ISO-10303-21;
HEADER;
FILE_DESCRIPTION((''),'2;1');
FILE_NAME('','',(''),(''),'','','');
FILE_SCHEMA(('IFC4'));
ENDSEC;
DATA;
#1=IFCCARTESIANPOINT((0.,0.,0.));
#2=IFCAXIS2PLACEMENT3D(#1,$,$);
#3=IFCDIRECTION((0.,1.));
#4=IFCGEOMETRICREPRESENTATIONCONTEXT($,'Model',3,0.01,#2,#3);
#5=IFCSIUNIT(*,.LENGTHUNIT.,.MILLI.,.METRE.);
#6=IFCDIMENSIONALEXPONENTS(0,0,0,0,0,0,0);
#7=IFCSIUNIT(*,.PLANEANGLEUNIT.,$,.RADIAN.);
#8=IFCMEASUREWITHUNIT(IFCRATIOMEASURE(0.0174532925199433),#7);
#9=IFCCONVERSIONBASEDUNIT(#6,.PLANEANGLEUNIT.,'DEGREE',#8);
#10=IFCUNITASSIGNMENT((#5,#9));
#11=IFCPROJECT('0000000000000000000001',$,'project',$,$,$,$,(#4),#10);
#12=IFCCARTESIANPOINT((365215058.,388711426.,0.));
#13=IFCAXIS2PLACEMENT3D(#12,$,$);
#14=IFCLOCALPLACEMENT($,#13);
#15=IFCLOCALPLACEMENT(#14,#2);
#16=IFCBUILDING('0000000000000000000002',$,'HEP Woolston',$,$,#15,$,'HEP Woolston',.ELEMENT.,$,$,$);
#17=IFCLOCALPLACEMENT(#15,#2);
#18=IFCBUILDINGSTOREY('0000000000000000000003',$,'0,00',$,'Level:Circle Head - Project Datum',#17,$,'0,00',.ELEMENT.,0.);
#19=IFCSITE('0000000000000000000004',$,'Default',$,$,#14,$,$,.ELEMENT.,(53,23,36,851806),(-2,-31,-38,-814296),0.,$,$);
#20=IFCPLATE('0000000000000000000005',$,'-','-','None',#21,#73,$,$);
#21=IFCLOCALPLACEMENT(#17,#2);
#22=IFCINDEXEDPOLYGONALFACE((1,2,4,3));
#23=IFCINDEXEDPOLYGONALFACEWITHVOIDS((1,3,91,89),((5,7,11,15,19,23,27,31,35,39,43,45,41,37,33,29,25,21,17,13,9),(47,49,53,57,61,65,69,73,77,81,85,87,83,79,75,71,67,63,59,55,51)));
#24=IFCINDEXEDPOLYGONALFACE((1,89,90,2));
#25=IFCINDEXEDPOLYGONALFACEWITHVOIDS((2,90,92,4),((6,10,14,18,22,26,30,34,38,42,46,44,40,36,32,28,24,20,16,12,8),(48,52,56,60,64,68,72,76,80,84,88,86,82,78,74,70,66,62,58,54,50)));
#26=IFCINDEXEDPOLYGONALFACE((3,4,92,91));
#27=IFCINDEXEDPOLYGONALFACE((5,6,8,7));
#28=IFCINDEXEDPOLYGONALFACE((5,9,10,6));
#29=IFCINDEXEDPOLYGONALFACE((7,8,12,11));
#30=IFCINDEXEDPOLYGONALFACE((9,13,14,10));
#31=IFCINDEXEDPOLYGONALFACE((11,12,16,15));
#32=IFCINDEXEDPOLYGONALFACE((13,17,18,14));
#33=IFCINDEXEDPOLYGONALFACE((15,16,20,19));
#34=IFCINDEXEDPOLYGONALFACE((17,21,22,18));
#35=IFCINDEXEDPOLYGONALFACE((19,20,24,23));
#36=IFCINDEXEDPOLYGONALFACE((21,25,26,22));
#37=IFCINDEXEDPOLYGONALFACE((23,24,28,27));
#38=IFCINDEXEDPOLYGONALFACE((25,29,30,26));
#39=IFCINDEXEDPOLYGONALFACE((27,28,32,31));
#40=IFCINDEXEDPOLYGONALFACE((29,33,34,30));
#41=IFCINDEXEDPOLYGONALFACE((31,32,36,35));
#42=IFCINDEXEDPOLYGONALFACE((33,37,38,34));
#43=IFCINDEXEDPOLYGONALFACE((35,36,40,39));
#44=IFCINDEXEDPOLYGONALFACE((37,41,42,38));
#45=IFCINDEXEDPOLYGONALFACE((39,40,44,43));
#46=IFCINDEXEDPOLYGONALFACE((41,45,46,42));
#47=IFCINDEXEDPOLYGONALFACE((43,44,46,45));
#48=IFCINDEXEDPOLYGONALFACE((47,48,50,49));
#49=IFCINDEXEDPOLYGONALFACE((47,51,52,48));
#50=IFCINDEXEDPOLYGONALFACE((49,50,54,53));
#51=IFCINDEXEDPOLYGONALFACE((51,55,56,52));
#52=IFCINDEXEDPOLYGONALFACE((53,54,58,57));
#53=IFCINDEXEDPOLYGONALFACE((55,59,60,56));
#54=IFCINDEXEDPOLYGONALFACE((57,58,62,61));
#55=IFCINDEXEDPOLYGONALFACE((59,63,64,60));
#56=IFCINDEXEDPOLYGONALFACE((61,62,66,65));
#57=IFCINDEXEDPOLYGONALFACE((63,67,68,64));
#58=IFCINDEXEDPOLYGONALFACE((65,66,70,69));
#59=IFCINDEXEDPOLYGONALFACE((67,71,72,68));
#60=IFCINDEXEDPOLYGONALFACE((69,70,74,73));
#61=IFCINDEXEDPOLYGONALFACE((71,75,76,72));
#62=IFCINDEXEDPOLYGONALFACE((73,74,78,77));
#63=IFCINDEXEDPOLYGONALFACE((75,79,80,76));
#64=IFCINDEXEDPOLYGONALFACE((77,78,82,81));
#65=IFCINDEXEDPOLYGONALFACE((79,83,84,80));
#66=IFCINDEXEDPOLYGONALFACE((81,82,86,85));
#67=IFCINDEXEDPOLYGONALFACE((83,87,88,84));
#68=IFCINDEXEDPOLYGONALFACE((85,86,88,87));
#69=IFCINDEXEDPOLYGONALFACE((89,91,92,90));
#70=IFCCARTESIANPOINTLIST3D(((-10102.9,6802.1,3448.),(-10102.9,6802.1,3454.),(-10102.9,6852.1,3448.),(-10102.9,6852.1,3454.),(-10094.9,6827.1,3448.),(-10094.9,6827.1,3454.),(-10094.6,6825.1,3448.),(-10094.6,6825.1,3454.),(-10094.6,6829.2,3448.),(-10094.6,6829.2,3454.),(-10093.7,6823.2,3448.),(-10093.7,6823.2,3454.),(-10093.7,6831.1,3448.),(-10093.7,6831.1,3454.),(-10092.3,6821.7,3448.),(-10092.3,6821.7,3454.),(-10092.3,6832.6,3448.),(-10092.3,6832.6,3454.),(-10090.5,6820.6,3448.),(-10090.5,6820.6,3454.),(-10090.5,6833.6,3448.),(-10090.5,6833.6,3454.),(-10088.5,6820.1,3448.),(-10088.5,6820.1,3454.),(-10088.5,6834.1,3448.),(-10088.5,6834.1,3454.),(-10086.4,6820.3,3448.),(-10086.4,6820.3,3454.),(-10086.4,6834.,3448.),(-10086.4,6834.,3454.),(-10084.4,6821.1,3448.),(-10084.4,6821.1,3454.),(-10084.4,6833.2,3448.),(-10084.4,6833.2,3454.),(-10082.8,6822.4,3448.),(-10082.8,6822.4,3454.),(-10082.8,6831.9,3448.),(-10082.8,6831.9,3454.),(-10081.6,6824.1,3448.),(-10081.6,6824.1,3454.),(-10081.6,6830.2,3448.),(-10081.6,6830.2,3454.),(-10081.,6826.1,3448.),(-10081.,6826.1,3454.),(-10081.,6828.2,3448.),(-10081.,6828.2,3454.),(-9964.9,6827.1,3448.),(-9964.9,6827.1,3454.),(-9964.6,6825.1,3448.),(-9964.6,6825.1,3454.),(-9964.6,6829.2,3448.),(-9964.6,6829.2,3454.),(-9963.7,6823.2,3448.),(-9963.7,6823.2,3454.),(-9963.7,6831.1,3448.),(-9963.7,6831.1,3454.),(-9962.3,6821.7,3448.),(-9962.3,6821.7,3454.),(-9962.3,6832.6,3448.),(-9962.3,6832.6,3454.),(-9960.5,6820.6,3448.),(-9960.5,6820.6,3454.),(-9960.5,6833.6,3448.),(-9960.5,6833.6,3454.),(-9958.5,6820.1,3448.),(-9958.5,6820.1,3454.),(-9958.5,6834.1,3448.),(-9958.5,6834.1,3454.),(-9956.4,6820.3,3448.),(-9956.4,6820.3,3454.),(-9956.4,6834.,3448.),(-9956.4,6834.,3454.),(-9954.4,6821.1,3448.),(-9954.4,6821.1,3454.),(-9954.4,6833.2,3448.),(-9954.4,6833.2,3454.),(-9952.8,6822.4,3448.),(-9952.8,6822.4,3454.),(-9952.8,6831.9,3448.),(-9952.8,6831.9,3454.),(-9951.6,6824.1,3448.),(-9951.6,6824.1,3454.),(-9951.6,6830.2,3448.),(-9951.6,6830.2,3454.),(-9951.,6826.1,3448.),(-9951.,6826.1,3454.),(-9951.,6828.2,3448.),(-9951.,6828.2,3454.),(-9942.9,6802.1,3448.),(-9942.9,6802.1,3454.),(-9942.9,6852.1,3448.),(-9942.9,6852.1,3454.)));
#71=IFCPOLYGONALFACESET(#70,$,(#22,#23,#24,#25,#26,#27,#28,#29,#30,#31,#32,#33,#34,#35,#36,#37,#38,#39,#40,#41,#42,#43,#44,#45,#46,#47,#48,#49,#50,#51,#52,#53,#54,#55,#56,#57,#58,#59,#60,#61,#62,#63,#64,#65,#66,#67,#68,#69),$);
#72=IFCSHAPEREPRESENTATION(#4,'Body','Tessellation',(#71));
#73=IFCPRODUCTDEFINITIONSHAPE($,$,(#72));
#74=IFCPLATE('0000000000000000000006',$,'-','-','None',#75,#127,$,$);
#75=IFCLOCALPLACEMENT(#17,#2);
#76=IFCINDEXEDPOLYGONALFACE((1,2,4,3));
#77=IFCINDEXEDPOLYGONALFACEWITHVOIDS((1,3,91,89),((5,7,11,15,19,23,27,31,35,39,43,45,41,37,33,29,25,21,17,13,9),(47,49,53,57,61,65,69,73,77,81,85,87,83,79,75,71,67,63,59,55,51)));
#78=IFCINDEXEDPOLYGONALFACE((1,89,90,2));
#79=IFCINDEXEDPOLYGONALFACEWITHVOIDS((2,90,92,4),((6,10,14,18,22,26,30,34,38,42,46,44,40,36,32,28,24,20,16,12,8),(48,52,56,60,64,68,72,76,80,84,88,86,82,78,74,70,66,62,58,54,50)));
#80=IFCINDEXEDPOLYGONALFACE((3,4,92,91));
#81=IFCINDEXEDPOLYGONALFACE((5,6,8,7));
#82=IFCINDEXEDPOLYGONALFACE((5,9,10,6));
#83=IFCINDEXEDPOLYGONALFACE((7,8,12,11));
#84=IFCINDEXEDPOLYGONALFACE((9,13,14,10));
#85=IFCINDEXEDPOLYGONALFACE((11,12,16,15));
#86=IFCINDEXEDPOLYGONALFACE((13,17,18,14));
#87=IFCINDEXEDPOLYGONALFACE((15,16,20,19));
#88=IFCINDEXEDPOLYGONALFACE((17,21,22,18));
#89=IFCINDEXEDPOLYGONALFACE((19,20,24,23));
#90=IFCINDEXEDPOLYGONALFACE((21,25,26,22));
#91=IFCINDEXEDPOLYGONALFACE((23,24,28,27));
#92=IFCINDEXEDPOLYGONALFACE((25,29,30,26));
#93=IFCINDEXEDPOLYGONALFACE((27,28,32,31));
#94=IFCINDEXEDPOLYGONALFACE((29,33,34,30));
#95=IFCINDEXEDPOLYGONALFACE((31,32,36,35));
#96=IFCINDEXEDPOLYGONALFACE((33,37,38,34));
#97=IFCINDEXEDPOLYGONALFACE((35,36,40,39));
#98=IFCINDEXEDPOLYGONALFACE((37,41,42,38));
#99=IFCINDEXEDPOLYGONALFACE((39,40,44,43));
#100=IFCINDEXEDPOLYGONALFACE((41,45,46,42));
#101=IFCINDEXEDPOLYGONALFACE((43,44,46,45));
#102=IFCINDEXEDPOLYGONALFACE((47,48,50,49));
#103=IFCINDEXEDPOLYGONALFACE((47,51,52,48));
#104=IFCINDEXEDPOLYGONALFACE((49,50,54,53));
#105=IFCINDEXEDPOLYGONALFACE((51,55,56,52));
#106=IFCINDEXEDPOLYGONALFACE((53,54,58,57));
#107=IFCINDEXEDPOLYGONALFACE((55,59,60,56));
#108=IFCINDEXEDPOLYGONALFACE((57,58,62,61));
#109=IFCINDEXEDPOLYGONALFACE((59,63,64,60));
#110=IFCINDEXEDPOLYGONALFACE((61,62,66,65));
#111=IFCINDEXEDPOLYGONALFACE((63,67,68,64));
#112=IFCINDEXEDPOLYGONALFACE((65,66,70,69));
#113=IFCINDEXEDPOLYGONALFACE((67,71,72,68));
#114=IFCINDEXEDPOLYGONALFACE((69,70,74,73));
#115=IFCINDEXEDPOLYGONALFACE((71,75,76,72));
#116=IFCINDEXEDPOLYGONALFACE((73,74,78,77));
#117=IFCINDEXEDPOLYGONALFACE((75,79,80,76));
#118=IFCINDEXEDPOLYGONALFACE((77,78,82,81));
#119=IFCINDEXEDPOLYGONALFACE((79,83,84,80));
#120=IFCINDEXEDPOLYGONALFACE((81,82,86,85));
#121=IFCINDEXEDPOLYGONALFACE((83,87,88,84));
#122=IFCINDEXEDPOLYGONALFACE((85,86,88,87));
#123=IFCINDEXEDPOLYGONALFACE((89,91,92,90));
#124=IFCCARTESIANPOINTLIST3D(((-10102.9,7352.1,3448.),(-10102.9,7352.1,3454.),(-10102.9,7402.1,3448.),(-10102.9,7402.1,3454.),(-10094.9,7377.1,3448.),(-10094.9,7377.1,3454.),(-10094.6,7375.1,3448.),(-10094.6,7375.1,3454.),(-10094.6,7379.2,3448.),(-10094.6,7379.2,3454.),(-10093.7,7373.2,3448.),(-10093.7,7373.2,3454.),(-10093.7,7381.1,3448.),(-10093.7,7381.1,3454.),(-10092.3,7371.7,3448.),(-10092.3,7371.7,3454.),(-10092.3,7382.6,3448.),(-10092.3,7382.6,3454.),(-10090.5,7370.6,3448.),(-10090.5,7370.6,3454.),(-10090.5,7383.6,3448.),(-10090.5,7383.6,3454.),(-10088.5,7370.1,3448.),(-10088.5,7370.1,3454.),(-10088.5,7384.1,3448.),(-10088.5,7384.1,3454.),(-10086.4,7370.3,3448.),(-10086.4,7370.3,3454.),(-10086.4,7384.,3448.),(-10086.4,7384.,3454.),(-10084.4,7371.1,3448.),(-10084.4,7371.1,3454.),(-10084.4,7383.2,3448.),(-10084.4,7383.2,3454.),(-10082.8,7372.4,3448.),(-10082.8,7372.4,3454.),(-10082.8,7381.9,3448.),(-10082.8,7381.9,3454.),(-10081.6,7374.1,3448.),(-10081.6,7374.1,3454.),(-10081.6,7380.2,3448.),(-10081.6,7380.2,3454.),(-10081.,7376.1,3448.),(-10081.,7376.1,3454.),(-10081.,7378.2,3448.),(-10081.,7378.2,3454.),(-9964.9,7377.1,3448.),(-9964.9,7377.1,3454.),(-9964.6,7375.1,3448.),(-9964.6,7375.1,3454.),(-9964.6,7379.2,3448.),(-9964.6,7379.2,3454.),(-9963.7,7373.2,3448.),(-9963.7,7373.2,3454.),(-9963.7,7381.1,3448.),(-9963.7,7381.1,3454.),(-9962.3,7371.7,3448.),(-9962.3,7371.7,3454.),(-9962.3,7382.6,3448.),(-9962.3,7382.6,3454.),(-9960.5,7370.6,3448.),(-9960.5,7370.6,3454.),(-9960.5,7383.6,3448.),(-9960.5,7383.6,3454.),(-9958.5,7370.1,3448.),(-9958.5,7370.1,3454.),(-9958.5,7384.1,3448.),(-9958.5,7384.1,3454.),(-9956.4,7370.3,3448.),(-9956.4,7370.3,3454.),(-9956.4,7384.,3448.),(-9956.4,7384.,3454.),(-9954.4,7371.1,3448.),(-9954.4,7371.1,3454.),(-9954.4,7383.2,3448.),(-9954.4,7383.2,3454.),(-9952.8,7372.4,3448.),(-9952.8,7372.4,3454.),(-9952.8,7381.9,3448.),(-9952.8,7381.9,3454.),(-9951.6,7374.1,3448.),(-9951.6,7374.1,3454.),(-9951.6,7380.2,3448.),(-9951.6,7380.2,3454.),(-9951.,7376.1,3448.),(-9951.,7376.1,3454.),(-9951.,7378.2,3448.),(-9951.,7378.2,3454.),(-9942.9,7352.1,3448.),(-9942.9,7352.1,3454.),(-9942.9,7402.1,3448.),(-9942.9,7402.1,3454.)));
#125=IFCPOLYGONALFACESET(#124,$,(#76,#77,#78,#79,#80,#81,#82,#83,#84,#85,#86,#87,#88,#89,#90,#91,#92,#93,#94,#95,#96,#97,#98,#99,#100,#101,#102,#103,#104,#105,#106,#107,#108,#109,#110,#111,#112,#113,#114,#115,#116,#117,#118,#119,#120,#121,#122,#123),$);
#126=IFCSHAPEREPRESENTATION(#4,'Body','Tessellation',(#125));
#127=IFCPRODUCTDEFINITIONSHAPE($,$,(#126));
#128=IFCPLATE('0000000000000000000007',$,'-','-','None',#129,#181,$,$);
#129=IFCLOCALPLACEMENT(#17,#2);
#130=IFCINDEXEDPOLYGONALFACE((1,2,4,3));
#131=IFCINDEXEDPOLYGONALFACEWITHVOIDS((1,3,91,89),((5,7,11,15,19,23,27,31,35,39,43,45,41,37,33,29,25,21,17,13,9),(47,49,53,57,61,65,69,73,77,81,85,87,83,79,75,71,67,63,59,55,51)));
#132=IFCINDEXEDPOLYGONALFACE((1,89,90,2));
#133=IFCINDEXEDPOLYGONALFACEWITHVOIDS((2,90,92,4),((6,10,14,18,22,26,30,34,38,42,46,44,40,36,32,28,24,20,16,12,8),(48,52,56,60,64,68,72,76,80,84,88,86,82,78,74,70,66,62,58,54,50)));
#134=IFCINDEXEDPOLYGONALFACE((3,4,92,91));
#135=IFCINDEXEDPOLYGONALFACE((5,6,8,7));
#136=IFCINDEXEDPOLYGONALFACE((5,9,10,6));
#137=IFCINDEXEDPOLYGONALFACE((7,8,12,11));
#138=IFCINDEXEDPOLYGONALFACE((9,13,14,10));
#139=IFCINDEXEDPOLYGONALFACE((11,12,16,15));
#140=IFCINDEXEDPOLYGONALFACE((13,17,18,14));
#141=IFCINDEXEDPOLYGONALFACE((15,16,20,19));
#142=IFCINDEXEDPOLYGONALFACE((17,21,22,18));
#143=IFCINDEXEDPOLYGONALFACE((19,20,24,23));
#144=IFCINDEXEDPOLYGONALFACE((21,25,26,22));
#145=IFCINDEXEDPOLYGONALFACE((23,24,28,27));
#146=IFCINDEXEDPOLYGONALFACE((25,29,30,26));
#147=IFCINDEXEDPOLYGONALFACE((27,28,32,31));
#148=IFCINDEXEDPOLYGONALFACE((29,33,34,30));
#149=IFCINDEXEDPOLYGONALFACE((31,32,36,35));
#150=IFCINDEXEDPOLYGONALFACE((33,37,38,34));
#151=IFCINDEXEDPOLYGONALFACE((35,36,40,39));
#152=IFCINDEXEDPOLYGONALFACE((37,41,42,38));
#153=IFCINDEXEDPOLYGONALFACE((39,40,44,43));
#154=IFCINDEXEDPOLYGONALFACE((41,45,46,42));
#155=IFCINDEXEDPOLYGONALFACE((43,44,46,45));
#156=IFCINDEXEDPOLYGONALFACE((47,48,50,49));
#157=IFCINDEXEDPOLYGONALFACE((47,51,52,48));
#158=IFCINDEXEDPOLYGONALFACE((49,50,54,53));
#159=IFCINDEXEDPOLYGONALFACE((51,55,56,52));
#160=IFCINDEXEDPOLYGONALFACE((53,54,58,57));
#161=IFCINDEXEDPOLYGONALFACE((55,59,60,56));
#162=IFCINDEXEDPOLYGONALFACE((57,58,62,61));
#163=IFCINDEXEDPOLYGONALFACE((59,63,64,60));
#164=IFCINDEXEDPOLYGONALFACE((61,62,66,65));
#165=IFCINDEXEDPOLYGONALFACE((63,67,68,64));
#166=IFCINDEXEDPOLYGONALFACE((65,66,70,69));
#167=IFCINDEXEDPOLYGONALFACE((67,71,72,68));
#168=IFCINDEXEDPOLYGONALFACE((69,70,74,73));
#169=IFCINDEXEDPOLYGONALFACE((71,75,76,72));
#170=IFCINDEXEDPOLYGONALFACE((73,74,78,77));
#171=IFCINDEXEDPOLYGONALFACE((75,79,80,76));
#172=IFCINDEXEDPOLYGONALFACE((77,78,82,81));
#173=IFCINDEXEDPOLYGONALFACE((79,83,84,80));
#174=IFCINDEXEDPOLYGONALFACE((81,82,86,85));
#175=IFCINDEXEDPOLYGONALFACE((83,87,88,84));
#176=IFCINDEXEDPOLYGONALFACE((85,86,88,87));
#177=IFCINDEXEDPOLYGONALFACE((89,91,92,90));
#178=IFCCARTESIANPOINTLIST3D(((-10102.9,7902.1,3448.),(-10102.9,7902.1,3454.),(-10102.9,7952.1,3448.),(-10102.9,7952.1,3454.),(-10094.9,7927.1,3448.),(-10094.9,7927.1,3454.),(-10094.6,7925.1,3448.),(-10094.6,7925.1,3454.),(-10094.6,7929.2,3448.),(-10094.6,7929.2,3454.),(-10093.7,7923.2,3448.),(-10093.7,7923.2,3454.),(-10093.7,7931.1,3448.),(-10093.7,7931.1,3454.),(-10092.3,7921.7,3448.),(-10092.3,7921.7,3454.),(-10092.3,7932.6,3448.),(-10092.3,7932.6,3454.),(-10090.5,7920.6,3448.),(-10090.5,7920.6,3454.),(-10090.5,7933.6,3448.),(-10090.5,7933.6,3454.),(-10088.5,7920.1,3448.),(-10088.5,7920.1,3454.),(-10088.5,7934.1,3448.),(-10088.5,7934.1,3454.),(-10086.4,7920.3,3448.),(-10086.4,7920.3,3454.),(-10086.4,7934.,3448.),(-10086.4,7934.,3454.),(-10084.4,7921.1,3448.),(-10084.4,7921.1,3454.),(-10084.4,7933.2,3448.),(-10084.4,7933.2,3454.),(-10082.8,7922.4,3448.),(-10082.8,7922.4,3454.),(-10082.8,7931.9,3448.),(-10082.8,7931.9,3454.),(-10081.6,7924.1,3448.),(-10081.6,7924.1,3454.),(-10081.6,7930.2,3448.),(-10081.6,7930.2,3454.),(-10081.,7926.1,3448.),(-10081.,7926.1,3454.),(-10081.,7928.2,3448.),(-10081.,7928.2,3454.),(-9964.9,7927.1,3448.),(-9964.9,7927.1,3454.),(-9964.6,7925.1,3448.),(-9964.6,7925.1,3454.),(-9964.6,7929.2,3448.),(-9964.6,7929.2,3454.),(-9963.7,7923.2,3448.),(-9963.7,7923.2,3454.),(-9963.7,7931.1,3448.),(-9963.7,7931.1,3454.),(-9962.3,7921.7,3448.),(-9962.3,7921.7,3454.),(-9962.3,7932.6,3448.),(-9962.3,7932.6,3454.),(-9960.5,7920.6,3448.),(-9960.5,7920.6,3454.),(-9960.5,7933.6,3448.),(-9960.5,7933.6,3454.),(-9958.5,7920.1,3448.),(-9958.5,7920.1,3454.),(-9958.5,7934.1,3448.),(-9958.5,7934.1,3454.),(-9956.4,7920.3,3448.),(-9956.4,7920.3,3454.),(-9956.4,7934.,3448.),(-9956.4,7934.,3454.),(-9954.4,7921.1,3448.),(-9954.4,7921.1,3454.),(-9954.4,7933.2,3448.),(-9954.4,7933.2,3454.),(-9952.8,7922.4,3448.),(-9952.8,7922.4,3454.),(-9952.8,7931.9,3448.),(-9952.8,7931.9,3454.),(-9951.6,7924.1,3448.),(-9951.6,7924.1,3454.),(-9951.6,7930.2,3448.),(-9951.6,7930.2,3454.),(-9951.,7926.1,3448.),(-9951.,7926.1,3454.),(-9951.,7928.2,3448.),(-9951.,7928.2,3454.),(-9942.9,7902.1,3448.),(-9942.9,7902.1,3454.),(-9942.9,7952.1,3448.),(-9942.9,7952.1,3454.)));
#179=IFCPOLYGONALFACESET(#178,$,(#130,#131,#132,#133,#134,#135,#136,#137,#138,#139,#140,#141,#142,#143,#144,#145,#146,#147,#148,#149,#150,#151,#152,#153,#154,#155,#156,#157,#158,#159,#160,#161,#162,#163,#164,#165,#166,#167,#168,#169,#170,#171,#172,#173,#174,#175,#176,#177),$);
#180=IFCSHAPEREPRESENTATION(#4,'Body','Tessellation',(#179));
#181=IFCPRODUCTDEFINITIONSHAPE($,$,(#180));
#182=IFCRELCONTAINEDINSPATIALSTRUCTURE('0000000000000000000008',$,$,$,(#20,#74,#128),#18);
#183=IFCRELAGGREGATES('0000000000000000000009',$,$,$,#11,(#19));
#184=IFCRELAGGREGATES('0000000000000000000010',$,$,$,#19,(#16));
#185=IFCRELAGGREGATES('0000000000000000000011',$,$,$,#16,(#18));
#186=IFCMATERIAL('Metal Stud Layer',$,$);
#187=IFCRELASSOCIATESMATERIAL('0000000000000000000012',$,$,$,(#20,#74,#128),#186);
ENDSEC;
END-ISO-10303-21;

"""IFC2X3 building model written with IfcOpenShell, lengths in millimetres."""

from ifc_helpers import new_model, entity, si_unit, converted_unit, direction, frame, frame_2d, origin, origin_with_axes, place, context, project, spatial, polyline, circle, outline, extrude, material, element, save


model = new_model("IFC2X3")

# Units and contexts
model_context = context("Model", 3, precision=0.01, world=origin(), true_north=direction((0.0, 1.0)))
ifc_project = project(units=[si_unit("LENGTHUNIT", "METRE", prefix="MILLI"), converted_unit("PLANEANGLEUNIT", "DEGREE", entity("IfcRatioMeasure", 0.0174532925199433), si_unit("PLANEANGLEUNIT", "RADIAN"), dimensions=[0, 0, 0, 0, 0, 0, 0])], contexts=[model_context])

# Site, building, storey
site_placement = place(None, frame((365215058.0, 388711426.0, 0.0)))
site = spatial("IfcSite", under=ifc_project, at=site_placement, Name="Default", CompositionType="ELEMENT", RefLatitude=(53, 23, 36, 851806), RefLongitude=(-2, -31, -38, -814296), RefElevation=0.0)
building_placement = place(site_placement, origin())
building = spatial("IfcBuilding", under=site, at=building_placement, Name="HEP Woolston", LongName="HEP Woolston", CompositionType="ELEMENT")
storey_placement = place(building_placement, origin())
storey = spatial("IfcBuildingStorey", under=building, at=storey_placement, Name="0,00", ObjectType="Level:Circle Head - Project Datum", LongName="0,00", CompositionType="ELEMENT", Elevation=0.0)

# Plates, openings
ifc_material_1 = material(Name="Metal Stud Layer")
plate_1_placement = place(storey_placement, frame((-9942.9, 6802.1, 3454.0), z_axis=(0.0, 0.0, -1.0), x_axis=(-1.0, 0.0, 0.0)))
plate_1 = element("IfcPlate", 1, at=plate_1_placement, inside=storey, material=ifc_material_1, Name="-", Description="-", ObjectType="None", context=model_context, shape_type="SweptSolid", body=[
    extrude(outline(polyline([(160.0, 0.0), (160.0, 50.0), (0.0, 50.0), (0.0, 0.0), (160.0, 0.0)])), origin_with_axes(), (0.0, 0.0, 1.0), 6.0),
])
opening_1_placement = place(plate_1_placement, frame((80.0, 25.0, 6.5), z_axis=(0.0, 0.0, -1.0), x_axis=(1.0, 0.0, 0.0)))
element("IfcOpeningElement", 2, at=opening_1_placement, cuts=plate_1, ObjectType="Opening", context=model_context, shape_type="SweptSolid", body=[
    extrude(circle(Radius=7.0, at=frame_2d((65.0, 0.0), x_axis=(1.0, 0.0))), origin(), (0.0, 0.0, 1.0), 7.0),
])
opening_2_placement = place(plate_1_placement, frame((80.0, 25.0, 6.5), z_axis=(0.0, 0.0, -1.0), x_axis=(1.0, 0.0, 0.0)))
element("IfcOpeningElement", 3, at=opening_2_placement, cuts=plate_1, ObjectType="Opening", context=model_context, shape_type="SweptSolid", body=[
    extrude(circle(Radius=7.0, at=frame_2d((-65.0, 0.0), x_axis=(1.0, 0.0))), origin(), (0.0, 0.0, 1.0), 7.0),
])
plate_2_placement = place(storey_placement, frame((-9942.9, 7352.1, 3454.0), z_axis=(0.0, 0.0, -1.0), x_axis=(-1.0, 0.0, 0.0)))
plate_2 = element("IfcPlate", 4, at=plate_2_placement, inside=storey, material=ifc_material_1, Name="-", Description="-", ObjectType="None", context=model_context, shape_type="SweptSolid", body=[
    extrude(outline(polyline([(160.0, 0.0), (160.0, 50.0), (0.0, 50.0), (0.0, 0.0), (160.0, 0.0)])), origin_with_axes(), (0.0, 0.0, 1.0), 6.0),
])
opening_3_placement = place(plate_2_placement, frame((80.0, 25.0, 6.5), z_axis=(0.0, 0.0, -1.0), x_axis=(1.0, 0.0, 0.0)))
element("IfcOpeningElement", 5, at=opening_3_placement, cuts=plate_2, ObjectType="Opening", context=model_context, shape_type="SweptSolid", body=[
    extrude(circle(Radius=7.0, at=frame_2d((65.0, 0.0), x_axis=(1.0, 0.0))), origin(), (0.0, 0.0, 1.0), 7.0),
])
opening_4_placement = place(plate_2_placement, frame((80.0, 25.0, 6.5), z_axis=(0.0, 0.0, -1.0), x_axis=(1.0, 0.0, 0.0)))
element("IfcOpeningElement", 6, at=opening_4_placement, cuts=plate_2, ObjectType="Opening", context=model_context, shape_type="SweptSolid", body=[
    extrude(circle(Radius=7.0, at=frame_2d((-65.0, 0.0), x_axis=(1.0, 0.0))), origin(), (0.0, 0.0, 1.0), 7.0),
])
plate_3_placement = place(storey_placement, frame((-9942.9, 7902.1, 3454.0), z_axis=(0.0, 0.0, -1.0), x_axis=(-1.0, 0.0, 0.0)))
plate_3 = element("IfcPlate", 7, at=plate_3_placement, inside=storey, material=ifc_material_1, Name="-", Description="-", ObjectType="None", context=model_context, shape_type="SweptSolid", body=[
    extrude(outline(polyline([(160.0, 0.0), (160.0, 50.0), (0.0, 50.0), (0.0, 0.0), (160.0, 0.0)])), origin_with_axes(), (0.0, 0.0, 1.0), 6.0),
])
opening_5_placement = place(plate_3_placement, frame((80.0, 25.0, 6.5), z_axis=(0.0, 0.0, -1.0), x_axis=(1.0, 0.0, 0.0)))
element("IfcOpeningElement", 8, at=opening_5_placement, cuts=plate_3, ObjectType="Opening", context=model_context, shape_type="SweptSolid", body=[
    extrude(circle(Radius=7.0, at=frame_2d((65.0, 0.0), x_axis=(1.0, 0.0))), origin(), (0.0, 0.0, 1.0), 7.0),
])
opening_6_placement = place(plate_3_placement, frame((80.0, 25.0, 6.5), z_axis=(0.0, 0.0, -1.0), x_axis=(1.0, 0.0, 0.0)))
element("IfcOpeningElement", 9, at=opening_6_placement, cuts=plate_3, ObjectType="Opening", context=model_context, shape_type="SweptSolid", body=[
    extrude(circle(Radius=7.0, at=frame_2d((-65.0, 0.0), x_axis=(1.0, 0.0))), origin(), (0.0, 0.0, 1.0), 7.0),
])

save(model, "model.ifc")
